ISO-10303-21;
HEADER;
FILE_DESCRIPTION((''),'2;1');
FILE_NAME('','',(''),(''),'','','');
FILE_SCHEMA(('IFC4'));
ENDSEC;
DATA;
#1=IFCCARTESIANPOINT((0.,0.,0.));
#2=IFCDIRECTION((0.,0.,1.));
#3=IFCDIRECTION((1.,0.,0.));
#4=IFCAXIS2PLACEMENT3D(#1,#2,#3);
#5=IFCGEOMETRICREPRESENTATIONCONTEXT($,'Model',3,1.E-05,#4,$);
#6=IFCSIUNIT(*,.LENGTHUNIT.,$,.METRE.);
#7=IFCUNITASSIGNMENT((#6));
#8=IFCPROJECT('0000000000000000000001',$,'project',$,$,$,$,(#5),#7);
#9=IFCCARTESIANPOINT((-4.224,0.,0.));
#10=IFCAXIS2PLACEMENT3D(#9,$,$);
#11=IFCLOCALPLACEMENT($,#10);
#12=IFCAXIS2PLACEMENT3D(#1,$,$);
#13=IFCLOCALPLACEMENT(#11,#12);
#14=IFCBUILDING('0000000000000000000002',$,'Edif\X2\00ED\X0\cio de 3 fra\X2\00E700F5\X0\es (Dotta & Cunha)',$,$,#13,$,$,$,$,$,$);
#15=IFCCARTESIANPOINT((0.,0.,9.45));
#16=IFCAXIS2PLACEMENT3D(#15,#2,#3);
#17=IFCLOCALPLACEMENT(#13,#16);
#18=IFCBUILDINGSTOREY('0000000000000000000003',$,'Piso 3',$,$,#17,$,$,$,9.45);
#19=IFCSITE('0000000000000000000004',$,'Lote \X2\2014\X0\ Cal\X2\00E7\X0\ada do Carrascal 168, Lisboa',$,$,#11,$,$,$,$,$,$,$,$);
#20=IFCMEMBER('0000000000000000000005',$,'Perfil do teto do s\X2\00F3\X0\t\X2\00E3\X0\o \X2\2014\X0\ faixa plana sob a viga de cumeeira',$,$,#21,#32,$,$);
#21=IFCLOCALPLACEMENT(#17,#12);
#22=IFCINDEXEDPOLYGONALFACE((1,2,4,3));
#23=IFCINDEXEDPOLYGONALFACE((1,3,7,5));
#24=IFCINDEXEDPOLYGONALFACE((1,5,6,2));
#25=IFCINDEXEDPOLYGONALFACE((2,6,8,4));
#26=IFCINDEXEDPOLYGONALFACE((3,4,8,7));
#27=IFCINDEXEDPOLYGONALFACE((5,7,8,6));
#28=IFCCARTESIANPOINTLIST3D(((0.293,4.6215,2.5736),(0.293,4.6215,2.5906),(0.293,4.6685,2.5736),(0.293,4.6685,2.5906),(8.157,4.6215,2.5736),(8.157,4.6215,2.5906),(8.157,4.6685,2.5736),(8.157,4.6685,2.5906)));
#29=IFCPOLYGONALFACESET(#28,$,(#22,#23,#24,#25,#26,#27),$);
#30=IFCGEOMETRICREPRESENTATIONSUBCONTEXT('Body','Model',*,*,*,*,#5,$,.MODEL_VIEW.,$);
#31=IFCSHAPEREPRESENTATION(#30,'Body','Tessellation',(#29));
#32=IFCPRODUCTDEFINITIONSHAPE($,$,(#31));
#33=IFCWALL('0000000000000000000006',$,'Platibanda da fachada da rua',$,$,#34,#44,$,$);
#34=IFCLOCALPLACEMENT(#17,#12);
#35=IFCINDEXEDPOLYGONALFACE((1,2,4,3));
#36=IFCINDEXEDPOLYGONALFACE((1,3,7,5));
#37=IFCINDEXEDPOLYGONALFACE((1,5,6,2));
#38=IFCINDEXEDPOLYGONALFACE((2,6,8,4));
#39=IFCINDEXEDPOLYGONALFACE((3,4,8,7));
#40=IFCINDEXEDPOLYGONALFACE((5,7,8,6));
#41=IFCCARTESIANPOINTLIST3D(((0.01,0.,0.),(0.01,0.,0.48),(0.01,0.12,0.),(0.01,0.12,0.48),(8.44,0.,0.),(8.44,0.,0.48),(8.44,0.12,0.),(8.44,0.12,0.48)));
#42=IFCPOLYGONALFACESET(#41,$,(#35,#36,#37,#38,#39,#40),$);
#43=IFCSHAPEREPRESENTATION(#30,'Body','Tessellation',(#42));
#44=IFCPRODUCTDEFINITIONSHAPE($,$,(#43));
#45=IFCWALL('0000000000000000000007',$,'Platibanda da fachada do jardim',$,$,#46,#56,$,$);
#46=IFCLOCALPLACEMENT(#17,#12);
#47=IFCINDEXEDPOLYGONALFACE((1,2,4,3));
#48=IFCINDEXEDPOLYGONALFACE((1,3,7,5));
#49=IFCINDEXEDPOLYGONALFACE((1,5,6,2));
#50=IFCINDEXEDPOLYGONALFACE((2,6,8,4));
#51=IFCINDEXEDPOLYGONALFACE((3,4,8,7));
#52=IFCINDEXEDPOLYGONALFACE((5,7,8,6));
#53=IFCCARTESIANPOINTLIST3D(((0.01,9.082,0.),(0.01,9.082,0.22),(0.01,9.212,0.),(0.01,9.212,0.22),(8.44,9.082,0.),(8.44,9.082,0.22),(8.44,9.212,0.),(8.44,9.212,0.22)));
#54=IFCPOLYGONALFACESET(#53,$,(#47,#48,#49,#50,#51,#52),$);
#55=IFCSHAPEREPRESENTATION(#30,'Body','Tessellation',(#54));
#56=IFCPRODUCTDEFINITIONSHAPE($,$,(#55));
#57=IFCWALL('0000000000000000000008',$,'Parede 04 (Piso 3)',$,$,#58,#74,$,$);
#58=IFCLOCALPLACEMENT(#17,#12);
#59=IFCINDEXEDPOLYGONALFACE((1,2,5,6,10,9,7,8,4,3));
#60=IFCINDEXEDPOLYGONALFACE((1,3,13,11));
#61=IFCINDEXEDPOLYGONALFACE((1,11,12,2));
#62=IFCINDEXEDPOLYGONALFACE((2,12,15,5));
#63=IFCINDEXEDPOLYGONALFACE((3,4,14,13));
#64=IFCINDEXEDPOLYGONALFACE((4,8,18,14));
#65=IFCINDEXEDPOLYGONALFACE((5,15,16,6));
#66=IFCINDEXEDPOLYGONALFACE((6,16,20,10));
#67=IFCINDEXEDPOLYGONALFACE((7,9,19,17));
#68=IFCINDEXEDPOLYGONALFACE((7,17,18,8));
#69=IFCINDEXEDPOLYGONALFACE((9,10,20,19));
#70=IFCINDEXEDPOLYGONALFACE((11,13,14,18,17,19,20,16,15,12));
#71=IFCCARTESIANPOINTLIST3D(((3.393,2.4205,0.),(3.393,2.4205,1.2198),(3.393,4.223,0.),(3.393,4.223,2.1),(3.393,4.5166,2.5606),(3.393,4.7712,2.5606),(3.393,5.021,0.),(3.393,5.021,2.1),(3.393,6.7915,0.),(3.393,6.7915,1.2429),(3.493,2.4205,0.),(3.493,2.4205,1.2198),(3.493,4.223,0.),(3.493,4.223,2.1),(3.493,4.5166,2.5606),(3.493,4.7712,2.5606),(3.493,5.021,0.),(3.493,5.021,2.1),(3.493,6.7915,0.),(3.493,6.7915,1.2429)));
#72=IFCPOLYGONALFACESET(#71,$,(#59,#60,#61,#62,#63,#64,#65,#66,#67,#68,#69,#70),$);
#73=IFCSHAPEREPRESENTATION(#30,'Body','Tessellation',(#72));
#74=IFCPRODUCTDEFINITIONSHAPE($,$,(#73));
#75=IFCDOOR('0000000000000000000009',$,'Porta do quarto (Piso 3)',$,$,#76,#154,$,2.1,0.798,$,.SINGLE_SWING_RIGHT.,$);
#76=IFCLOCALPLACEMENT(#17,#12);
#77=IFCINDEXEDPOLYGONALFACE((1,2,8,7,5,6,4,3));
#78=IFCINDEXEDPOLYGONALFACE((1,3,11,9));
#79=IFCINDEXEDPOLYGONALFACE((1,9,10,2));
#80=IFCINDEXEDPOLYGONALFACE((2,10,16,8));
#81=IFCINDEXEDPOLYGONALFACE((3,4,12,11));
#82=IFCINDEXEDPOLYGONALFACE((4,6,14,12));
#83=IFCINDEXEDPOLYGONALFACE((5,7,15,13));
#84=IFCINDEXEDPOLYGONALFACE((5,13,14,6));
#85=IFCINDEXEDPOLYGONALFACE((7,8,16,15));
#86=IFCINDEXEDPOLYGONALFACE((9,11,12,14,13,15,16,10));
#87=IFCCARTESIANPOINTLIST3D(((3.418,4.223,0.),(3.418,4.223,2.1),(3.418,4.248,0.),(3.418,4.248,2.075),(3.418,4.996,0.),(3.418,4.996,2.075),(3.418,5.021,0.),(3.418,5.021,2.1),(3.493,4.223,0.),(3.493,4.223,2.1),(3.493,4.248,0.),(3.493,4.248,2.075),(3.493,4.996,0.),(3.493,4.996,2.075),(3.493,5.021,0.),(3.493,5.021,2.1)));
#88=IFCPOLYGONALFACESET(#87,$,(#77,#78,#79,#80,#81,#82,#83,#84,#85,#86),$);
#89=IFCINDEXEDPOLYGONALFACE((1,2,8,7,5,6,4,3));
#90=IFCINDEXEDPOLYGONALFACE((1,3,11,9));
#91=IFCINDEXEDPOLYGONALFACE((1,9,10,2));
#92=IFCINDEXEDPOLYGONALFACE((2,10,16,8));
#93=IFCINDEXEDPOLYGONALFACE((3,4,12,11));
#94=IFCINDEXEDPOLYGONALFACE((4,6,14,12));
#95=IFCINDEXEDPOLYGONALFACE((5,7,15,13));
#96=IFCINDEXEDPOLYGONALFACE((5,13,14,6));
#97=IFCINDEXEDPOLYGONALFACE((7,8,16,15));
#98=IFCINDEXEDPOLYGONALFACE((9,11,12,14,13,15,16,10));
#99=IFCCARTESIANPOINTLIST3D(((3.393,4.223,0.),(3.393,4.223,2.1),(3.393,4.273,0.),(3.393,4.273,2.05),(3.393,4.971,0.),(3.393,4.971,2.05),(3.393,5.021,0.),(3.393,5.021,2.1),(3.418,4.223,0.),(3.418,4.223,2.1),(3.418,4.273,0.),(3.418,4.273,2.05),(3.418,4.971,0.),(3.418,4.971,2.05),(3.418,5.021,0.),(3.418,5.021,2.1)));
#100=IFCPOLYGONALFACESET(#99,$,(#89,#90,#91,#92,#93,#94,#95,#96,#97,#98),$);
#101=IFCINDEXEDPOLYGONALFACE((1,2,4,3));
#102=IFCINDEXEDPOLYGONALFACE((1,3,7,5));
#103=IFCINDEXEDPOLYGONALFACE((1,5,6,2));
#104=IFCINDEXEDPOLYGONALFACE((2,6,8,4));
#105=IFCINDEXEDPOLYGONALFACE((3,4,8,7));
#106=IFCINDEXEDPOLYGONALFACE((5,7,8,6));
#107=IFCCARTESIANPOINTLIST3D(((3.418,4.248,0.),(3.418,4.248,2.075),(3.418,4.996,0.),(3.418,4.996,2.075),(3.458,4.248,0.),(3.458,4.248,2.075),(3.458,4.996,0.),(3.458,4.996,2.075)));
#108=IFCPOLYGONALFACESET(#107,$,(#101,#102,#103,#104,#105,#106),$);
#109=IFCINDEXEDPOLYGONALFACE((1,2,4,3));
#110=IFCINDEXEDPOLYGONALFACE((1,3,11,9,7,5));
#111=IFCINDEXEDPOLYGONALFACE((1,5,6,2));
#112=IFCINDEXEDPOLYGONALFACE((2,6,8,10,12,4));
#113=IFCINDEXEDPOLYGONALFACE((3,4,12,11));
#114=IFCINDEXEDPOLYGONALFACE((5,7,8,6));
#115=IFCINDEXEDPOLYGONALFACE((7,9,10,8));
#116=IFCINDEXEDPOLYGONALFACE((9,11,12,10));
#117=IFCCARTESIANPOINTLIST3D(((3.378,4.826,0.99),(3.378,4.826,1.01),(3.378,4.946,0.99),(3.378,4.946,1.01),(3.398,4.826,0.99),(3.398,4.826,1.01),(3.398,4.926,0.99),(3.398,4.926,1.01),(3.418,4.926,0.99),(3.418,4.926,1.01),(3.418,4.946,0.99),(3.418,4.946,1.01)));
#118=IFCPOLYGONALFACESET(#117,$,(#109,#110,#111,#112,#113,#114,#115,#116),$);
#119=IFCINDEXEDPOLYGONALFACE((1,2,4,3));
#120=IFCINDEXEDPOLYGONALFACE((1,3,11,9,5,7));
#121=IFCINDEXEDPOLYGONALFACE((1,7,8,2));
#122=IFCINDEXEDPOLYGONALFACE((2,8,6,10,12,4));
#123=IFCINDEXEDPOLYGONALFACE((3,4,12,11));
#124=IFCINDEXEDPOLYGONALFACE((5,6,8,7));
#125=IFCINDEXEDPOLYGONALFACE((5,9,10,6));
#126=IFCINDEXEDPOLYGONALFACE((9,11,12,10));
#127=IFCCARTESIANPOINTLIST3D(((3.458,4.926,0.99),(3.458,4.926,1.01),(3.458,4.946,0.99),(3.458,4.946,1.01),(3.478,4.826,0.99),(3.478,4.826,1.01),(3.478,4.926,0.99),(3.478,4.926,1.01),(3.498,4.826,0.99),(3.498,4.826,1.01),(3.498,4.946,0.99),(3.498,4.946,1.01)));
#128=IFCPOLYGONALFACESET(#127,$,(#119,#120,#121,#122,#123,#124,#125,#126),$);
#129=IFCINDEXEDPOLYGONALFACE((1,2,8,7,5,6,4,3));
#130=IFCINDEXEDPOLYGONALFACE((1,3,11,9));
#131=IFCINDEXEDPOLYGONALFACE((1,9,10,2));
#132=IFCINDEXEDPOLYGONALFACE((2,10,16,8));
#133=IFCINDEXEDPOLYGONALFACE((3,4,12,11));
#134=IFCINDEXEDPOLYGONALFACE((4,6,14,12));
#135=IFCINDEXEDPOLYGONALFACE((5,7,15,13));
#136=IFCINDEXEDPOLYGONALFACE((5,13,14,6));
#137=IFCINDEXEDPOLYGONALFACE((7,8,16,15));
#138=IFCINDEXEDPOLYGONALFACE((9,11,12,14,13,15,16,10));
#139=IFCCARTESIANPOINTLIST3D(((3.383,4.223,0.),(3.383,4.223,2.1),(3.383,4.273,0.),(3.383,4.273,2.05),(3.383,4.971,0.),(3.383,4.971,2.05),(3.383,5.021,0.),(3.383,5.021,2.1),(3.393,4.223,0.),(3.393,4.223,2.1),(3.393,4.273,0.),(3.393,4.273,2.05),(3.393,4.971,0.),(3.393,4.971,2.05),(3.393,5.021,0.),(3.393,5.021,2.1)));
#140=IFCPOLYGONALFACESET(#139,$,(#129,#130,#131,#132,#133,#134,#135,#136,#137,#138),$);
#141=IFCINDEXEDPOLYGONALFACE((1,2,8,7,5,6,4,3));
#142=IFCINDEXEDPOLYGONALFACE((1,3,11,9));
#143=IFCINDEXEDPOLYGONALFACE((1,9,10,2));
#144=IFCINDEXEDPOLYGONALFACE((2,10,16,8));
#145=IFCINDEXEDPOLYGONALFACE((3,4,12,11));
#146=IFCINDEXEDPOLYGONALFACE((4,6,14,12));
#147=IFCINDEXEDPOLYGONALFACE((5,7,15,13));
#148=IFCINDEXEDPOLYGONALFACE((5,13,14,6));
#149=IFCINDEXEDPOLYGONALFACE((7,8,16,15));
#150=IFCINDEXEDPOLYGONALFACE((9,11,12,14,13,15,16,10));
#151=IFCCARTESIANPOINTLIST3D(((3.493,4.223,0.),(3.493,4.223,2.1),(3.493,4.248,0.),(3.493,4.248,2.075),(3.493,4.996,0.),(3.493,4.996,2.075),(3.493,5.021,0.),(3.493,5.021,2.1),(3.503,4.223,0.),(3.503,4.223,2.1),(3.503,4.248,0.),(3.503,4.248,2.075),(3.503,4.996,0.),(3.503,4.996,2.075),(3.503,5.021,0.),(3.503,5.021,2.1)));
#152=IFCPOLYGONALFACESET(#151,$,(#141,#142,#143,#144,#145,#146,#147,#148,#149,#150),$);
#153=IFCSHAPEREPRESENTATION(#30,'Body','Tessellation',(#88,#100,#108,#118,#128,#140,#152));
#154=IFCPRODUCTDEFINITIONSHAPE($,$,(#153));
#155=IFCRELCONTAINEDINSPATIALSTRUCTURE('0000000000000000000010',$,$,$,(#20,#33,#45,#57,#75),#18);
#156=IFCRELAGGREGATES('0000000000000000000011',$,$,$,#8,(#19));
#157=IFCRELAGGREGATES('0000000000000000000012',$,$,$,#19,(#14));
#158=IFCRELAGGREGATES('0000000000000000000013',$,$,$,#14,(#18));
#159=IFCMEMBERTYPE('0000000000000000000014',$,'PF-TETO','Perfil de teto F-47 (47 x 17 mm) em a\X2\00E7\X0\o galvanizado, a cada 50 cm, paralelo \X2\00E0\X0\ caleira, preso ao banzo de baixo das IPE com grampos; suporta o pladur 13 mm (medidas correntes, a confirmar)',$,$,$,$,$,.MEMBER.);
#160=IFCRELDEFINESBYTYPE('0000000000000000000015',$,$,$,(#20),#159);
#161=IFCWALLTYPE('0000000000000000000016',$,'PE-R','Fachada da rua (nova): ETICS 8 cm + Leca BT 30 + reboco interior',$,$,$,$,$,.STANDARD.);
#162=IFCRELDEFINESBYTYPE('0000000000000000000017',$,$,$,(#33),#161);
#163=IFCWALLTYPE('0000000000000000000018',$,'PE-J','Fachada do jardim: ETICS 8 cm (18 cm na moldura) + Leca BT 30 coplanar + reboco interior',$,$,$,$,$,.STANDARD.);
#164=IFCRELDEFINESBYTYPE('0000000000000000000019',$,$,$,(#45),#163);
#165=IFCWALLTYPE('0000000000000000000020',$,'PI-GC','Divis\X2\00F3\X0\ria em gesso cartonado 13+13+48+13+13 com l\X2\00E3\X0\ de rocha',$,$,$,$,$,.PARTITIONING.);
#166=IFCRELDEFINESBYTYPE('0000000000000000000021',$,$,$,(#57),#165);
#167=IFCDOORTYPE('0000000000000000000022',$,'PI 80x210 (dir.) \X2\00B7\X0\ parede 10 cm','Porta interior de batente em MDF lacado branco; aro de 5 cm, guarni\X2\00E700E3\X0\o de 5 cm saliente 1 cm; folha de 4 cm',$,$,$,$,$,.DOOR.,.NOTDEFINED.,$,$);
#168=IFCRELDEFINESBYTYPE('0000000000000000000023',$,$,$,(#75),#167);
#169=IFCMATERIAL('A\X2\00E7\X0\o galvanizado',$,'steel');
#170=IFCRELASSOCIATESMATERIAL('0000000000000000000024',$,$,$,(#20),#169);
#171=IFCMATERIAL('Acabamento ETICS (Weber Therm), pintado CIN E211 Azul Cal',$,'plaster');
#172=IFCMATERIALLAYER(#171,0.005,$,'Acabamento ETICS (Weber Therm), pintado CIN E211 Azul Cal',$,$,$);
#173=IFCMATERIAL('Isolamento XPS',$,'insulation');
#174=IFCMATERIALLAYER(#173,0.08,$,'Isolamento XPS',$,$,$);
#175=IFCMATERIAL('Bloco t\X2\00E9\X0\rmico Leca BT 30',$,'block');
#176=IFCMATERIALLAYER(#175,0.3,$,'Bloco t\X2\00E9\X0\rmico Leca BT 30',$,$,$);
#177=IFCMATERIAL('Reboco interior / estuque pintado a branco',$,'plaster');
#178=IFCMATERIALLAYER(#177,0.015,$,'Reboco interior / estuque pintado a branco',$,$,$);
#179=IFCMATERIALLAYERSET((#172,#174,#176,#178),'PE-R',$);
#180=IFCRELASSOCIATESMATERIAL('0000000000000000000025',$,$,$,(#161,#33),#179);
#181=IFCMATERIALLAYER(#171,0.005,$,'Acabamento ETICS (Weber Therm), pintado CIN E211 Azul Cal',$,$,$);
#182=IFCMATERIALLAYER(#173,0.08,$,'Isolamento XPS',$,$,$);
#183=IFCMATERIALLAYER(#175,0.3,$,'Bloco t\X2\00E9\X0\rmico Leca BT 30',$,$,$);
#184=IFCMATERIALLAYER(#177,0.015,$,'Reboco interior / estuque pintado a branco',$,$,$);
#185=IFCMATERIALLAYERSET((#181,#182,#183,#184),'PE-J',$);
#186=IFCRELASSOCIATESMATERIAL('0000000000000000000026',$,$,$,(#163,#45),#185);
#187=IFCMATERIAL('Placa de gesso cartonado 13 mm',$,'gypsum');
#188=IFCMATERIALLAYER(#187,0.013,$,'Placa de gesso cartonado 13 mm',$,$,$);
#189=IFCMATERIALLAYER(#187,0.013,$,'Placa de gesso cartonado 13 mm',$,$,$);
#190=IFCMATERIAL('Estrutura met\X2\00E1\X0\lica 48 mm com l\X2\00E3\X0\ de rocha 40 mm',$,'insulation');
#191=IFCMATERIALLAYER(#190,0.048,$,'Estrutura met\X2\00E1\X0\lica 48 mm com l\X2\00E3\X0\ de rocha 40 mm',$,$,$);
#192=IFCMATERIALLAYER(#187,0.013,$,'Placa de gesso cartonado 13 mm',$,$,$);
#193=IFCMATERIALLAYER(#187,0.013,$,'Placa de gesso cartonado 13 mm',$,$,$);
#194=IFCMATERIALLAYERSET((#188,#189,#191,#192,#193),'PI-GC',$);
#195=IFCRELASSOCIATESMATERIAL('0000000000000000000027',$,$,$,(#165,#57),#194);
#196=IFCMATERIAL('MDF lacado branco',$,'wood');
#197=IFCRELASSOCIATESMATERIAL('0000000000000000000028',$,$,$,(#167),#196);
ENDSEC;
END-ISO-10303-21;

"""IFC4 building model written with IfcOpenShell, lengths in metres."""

from ifc_helpers import new_model, si_unit, frame, origin, origin_with_axes, place, context, subcontext, project, spatial, line, indexed_curve, outline, extrude, clip, halfspace, source, transform, mapped, material, layer, layer_set, layer_usage, type_object, type_shapes, element, fill, save


model = new_model("IFC4")

# Units and contexts
model_context = context("Model", 3, precision=1e-05, world=origin_with_axes())
body_context = subcontext(model_context, "Body", "Model", "MODEL_VIEW")
ifc_project = project(units=[si_unit("LENGTHUNIT", "METRE")], contexts=[model_context])

# Site, building, storey
site_placement = place(None, frame((-4.224, 0.0, 0.0)))
site = spatial("IfcSite", under=ifc_project, at=site_placement, Name="Lote — Calçada do Carrascal 168, Lisboa")
building_placement = place(site_placement, origin())
building = spatial("IfcBuilding", under=site, at=building_placement, Name="Edifício de 3 frações (Dotta & Cunha)")
storey_placement = place(building_placement, frame((0.0, 0.0, 9.45), z_axis=(0.0, 0.0, 1.0), x_axis=(1.0, 0.0, 0.0)))
storey = spatial("IfcBuildingStorey", under=building, at=storey_placement, Name="Piso 3", Elevation=9.45)

# Member
ifc_material_1 = material(Name="Aço galvanizado", Category="steel")
member_type_1 = type_object("IfcMemberType", Name="PF-TETO", Description="Perfil de teto F-47 (47 x 17 mm) em aço galvanizado, a cada 50 cm, paralelo à caleira, preso ao banzo de baixo das IPE com grampos; suporta o pladur 13 mm (medidas correntes, a confirmar)", PredefinedType="MEMBER")
member_1_placement = place(storey_placement, frame((0.0, 0.0, 2.5736), z_axis=(0.0, 0.0, 1.0), x_axis=(1.0, 0.0, 0.0)))
element("IfcMember", 1, at=member_1_placement, inside=storey, type_object=member_type_1, material=ifc_material_1, Name="Perfil do teto do sótão — faixa plana sob a viga de cumeeira", context=body_context, shape_type="SweptSolid", body=[
    extrude(outline(indexed_curve([(8.157, 4.6215), (0.293, 4.6215), (0.293, 4.6685), (8.157, 4.6685)], segments=[line(1, 2, 3, 4, 1)])), origin_with_axes(), (0.0, 0.0, 1.0), 0.017),
])

# Walls
ifc_material_2 = material(Name="Acabamento ETICS (Weber Therm), pintado CIN E211 Azul Cal", Category="plaster")
ifc_layer_1 = layer(ifc_material_2, 0.005, Name="Acabamento ETICS (Weber Therm), pintado CIN E211 Azul Cal")
ifc_material_3 = material(Name="Isolamento XPS", Category="insulation")
ifc_layer_2 = layer(ifc_material_3, 0.08, Name="Isolamento XPS")
ifc_material_4 = material(Name="Bloco térmico Leca BT 30", Category="block")
ifc_layer_3 = layer(ifc_material_4, 0.3, Name="Bloco térmico Leca BT 30")
ifc_material_5 = material(Name="Reboco interior / estuque pintado a branco", Category="plaster")
ifc_layer_4 = layer(ifc_material_5, 0.015, Name="Reboco interior / estuque pintado a branco")
ifc_layer_set_1 = layer_set([ifc_layer_1, ifc_layer_2, ifc_layer_3, ifc_layer_4], Name="PE-R")
ifc_layer_usage_1 = layer_usage(ifc_layer_set_1, "AXIS2", "POSITIVE", 0.0)
wall_type_1 = type_object("IfcWallType", Name="PE-R", Description="Fachada da rua (nova): ETICS 8 cm + Leca BT 30 + reboco interior", PredefinedType="STANDARD", material=ifc_layer_set_1)
wall_1_placement = place(storey_placement, origin_with_axes())
element("IfcWall", 2, at=wall_1_placement, inside=storey, type_object=wall_type_1, material=ifc_layer_usage_1, Name="Platibanda da fachada da rua", context=body_context, shape_type="SweptSolid", body=[
    extrude(outline(indexed_curve([(8.44, 0.0), (8.44, 0.12), (0.01, 0.12), (0.01, 0.0)], segments=[line(1, 2, 3, 4, 1)])), origin_with_axes(), (0.0, 0.0, 1.0), 0.48),
])
ifc_layer_5 = layer(ifc_material_2, 0.005, Name="Acabamento ETICS (Weber Therm), pintado CIN E211 Azul Cal")
ifc_layer_6 = layer(ifc_material_3, 0.08, Name="Isolamento XPS")
ifc_layer_7 = layer(ifc_material_4, 0.3, Name="Bloco térmico Leca BT 30")
ifc_layer_8 = layer(ifc_material_5, 0.015, Name="Reboco interior / estuque pintado a branco")
ifc_layer_set_2 = layer_set([ifc_layer_5, ifc_layer_6, ifc_layer_7, ifc_layer_8], Name="PE-J")
ifc_layer_usage_2 = layer_usage(ifc_layer_set_2, "AXIS2", "NEGATIVE", 9.212)
wall_type_2 = type_object("IfcWallType", Name="PE-J", Description="Fachada do jardim: ETICS 8 cm (18 cm na moldura) + Leca BT 30 coplanar + reboco interior", PredefinedType="STANDARD", material=ifc_layer_set_2)
wall_2_placement = place(storey_placement, origin_with_axes())
element("IfcWall", 3, at=wall_2_placement, inside=storey, type_object=wall_type_2, material=ifc_layer_usage_2, Name="Platibanda da fachada do jardim", context=body_context, shape_type="SweptSolid", body=[
    extrude(outline(indexed_curve([(8.44, 9.082), (8.44, 9.212), (0.01, 9.212), (0.01, 9.082)], segments=[line(1, 2, 3, 4, 1)])), origin_with_axes(), (0.0, 0.0, 1.0), 0.22),
])

# Wall, opening, door
ifc_material_6 = material(Name="Placa de gesso cartonado 13 mm", Category="gypsum")
ifc_layer_9 = layer(ifc_material_6, 0.013, Name="Placa de gesso cartonado 13 mm")
ifc_layer_10 = layer(ifc_material_6, 0.013, Name="Placa de gesso cartonado 13 mm")
ifc_material_7 = material(Name="Estrutura metálica 48 mm com lã de rocha 40 mm", Category="insulation")
ifc_layer_11 = layer(ifc_material_7, 0.048, Name="Estrutura metálica 48 mm com lã de rocha 40 mm")
ifc_layer_12 = layer(ifc_material_6, 0.013, Name="Placa de gesso cartonado 13 mm")
ifc_layer_13 = layer(ifc_material_6, 0.013, Name="Placa de gesso cartonado 13 mm")
ifc_layer_set_3 = layer_set([ifc_layer_9, ifc_layer_10, ifc_layer_11, ifc_layer_12, ifc_layer_13], Name="PI-GC")
ifc_layer_usage_3 = layer_usage(ifc_layer_set_3, "AXIS2", "POSITIVE", 0.0)
wall_type_3 = type_object("IfcWallType", Name="PI-GC", Description="Divisória em gesso cartonado 13+13+48+13+13 com lã de rocha", PredefinedType="PARTITIONING", material=ifc_layer_set_3)
wall_3_placement = place(storey_placement, origin_with_axes())
wall_3 = element("IfcWall", 4, at=wall_3_placement, inside=storey, type_object=wall_type_3, material=ifc_layer_usage_3, Name="Parede 04 (Piso 3)", context=body_context, shape_type="Clipping", body=[
    clip(clip(extrude(outline(indexed_curve([(3.493, 2.4205), (3.493, 6.7915), (3.393, 6.7915), (3.393, 2.4205)], segments=[line(1, 2, 3, 4, 1)])), origin_with_axes(), (0.0, 0.0, 1.0), 2.5606), halfspace(frame((0.0, -4.1406, -2.9773), z_axis=(0.0, -0.538875, 0.842386), x_axis=(1.0, 0.0, 0.0)), False)), halfspace(frame((0.0, 6.9196, 1.1594), z_axis=(0.0, 0.546292, 0.837595), x_axis=(1.0, 0.0, 0.0)), False)),
])
opening_1_placement = place(wall_3_placement, origin_with_axes())
opening_1 = element("IfcOpeningElement", 5, at=opening_1_placement, cuts=wall_3, context=body_context, shape_type="SweptSolid", body=[
    extrude(outline(indexed_curve([(3.495, 4.223), (3.495, 5.021), (3.391, 5.021), (3.391, 4.223)], segments=[line(1, 2, 3, 4, 1)])), origin_with_axes(), (0.0, 0.0, 1.0), 2.1),
])
ifc_material_8 = material(Name="MDF lacado branco", Category="wood")
door_type_1 = type_object("IfcDoorType", Name="PI 80x210 (dir.) · parede 10 cm", Description="Porta interior de batente em MDF lacado branco; aro de 5 cm, guarnição de 5 cm saliente 1 cm; folha de 4 cm", OperationType="NOTDEFINED", PredefinedType="DOOR", material=ifc_material_8)
shared_shape_1 = source(origin_with_axes(), body_context, "Body", "SweptSolid", [
    extrude(outline(indexed_curve([(0.0, 0.0), (0.0, 2.1), (0.798, 2.1), (0.798, 0.0), (0.773, 0.0), (0.773, 2.075), (0.025, 2.075), (0.025, 0.0)], segments=[line(1, 2, 3, 4, 5, 6, 7, 8, 1)])), frame((0.0, 0.025, 0.0), z_axis=(0.0, -1.0, 0.0), x_axis=(1.0, 0.0, 0.0)), (0.0, 0.0, -1.0), 0.075),
    extrude(outline(indexed_curve([(0.0, 0.0), (0.0, 2.1), (0.798, 2.1), (0.798, 0.0), (0.748, 0.0), (0.748, 2.05), (0.05, 2.05), (0.05, 0.0)], segments=[line(1, 2, 3, 4, 5, 6, 7, 8, 1)])), frame((0.0, 0.0, 0.0), z_axis=(0.0, -1.0, 0.0), x_axis=(1.0, 0.0, 0.0)), (0.0, 0.0, -1.0), 0.025),
    extrude(outline(indexed_curve([(0.0, 0.0), (0.748, 0.0), (0.748, 0.04), (0.0, 0.04)], segments=[line(1, 2, 3, 4, 1)])), frame((0.025, 0.025, 0.0), z_axis=(0.0, 0.0, 1.0), x_axis=(1.0, 0.0, 0.0)), (0.0, 0.0, 1.0), 2.075),
    extrude(outline(indexed_curve([(0.0, 0.0), (0.0, -0.04), (0.12, -0.04), (0.12, -0.02), (0.02, -0.02), (0.02, 0.0)], segments=[line(1, 2, 3, 4, 5, 6, 1)])), frame((0.075, 0.025, 0.99), z_axis=(0.0, 0.0, 1.0), x_axis=(1.0, 0.0, 0.0)), (0.0, 0.0, 1.0), 0.02),
    extrude(outline(indexed_curve([(0.0, 0.0), (0.0, 0.04), (0.12, 0.04), (0.12, 0.02), (0.02, 0.02), (0.02, 0.0)], segments=[line(1, 2, 3, 4, 5, 6, 1)])), frame((0.075, 0.065, 0.99), z_axis=(0.0, 0.0, 1.0), x_axis=(1.0, 0.0, 0.0)), (0.0, 0.0, 1.0), 0.02),
    extrude(outline(indexed_curve([(0.0, 0.0), (0.0, 2.1), (0.798, 2.1), (0.798, 0.0), (0.748, 0.0), (0.748, 2.05), (0.05, 2.05), (0.05, 0.0)], segments=[line(1, 2, 3, 4, 5, 6, 7, 8, 1)])), frame((0.0, -0.01, 0.0), z_axis=(0.0, -1.0, 0.0), x_axis=(1.0, 0.0, 0.0)), (0.0, 0.0, -1.0), 0.01),
    extrude(outline(indexed_curve([(0.0, 0.0), (0.0, 2.1), (0.798, 2.1), (0.798, 0.0), (0.773, 0.0), (0.773, 2.075), (0.025, 2.075), (0.025, 0.0)], segments=[line(1, 2, 3, 4, 5, 6, 7, 8, 1)])), frame((0.0, 0.1, 0.0), z_axis=(0.0, -1.0, 0.0), x_axis=(1.0, 0.0, 0.0)), (0.0, 0.0, -1.0), 0.01),
])
type_shapes(door_type_1, [shared_shape_1])
door_1_placement = place(storey_placement, frame((3.393, 5.021, 0.0), z_axis=(0.0, 0.0, 1.0), x_axis=(0.0, -1.0, 0.0)))
door_1 = element("IfcDoor", 6, at=door_1_placement, inside=storey, type_object=door_type_1, Name="Porta do quarto (Piso 3)", OperationType="SINGLE_SWING_RIGHT", OverallHeight=2.1, OverallWidth=0.798, context=body_context, shape_type="MappedRepresentation", body=[
    mapped(shared_shape_1, transform((0.0, 0.0, 0.0), x_axis=(1.0, 0.0, 0.0), y_axis=(0.0, 1.0, 0.0), z_axis=(0.0, 0.0, 1.0), scale=1.0)),
])
fill(opening_1, door_1)

save(model, "model.ifc")
